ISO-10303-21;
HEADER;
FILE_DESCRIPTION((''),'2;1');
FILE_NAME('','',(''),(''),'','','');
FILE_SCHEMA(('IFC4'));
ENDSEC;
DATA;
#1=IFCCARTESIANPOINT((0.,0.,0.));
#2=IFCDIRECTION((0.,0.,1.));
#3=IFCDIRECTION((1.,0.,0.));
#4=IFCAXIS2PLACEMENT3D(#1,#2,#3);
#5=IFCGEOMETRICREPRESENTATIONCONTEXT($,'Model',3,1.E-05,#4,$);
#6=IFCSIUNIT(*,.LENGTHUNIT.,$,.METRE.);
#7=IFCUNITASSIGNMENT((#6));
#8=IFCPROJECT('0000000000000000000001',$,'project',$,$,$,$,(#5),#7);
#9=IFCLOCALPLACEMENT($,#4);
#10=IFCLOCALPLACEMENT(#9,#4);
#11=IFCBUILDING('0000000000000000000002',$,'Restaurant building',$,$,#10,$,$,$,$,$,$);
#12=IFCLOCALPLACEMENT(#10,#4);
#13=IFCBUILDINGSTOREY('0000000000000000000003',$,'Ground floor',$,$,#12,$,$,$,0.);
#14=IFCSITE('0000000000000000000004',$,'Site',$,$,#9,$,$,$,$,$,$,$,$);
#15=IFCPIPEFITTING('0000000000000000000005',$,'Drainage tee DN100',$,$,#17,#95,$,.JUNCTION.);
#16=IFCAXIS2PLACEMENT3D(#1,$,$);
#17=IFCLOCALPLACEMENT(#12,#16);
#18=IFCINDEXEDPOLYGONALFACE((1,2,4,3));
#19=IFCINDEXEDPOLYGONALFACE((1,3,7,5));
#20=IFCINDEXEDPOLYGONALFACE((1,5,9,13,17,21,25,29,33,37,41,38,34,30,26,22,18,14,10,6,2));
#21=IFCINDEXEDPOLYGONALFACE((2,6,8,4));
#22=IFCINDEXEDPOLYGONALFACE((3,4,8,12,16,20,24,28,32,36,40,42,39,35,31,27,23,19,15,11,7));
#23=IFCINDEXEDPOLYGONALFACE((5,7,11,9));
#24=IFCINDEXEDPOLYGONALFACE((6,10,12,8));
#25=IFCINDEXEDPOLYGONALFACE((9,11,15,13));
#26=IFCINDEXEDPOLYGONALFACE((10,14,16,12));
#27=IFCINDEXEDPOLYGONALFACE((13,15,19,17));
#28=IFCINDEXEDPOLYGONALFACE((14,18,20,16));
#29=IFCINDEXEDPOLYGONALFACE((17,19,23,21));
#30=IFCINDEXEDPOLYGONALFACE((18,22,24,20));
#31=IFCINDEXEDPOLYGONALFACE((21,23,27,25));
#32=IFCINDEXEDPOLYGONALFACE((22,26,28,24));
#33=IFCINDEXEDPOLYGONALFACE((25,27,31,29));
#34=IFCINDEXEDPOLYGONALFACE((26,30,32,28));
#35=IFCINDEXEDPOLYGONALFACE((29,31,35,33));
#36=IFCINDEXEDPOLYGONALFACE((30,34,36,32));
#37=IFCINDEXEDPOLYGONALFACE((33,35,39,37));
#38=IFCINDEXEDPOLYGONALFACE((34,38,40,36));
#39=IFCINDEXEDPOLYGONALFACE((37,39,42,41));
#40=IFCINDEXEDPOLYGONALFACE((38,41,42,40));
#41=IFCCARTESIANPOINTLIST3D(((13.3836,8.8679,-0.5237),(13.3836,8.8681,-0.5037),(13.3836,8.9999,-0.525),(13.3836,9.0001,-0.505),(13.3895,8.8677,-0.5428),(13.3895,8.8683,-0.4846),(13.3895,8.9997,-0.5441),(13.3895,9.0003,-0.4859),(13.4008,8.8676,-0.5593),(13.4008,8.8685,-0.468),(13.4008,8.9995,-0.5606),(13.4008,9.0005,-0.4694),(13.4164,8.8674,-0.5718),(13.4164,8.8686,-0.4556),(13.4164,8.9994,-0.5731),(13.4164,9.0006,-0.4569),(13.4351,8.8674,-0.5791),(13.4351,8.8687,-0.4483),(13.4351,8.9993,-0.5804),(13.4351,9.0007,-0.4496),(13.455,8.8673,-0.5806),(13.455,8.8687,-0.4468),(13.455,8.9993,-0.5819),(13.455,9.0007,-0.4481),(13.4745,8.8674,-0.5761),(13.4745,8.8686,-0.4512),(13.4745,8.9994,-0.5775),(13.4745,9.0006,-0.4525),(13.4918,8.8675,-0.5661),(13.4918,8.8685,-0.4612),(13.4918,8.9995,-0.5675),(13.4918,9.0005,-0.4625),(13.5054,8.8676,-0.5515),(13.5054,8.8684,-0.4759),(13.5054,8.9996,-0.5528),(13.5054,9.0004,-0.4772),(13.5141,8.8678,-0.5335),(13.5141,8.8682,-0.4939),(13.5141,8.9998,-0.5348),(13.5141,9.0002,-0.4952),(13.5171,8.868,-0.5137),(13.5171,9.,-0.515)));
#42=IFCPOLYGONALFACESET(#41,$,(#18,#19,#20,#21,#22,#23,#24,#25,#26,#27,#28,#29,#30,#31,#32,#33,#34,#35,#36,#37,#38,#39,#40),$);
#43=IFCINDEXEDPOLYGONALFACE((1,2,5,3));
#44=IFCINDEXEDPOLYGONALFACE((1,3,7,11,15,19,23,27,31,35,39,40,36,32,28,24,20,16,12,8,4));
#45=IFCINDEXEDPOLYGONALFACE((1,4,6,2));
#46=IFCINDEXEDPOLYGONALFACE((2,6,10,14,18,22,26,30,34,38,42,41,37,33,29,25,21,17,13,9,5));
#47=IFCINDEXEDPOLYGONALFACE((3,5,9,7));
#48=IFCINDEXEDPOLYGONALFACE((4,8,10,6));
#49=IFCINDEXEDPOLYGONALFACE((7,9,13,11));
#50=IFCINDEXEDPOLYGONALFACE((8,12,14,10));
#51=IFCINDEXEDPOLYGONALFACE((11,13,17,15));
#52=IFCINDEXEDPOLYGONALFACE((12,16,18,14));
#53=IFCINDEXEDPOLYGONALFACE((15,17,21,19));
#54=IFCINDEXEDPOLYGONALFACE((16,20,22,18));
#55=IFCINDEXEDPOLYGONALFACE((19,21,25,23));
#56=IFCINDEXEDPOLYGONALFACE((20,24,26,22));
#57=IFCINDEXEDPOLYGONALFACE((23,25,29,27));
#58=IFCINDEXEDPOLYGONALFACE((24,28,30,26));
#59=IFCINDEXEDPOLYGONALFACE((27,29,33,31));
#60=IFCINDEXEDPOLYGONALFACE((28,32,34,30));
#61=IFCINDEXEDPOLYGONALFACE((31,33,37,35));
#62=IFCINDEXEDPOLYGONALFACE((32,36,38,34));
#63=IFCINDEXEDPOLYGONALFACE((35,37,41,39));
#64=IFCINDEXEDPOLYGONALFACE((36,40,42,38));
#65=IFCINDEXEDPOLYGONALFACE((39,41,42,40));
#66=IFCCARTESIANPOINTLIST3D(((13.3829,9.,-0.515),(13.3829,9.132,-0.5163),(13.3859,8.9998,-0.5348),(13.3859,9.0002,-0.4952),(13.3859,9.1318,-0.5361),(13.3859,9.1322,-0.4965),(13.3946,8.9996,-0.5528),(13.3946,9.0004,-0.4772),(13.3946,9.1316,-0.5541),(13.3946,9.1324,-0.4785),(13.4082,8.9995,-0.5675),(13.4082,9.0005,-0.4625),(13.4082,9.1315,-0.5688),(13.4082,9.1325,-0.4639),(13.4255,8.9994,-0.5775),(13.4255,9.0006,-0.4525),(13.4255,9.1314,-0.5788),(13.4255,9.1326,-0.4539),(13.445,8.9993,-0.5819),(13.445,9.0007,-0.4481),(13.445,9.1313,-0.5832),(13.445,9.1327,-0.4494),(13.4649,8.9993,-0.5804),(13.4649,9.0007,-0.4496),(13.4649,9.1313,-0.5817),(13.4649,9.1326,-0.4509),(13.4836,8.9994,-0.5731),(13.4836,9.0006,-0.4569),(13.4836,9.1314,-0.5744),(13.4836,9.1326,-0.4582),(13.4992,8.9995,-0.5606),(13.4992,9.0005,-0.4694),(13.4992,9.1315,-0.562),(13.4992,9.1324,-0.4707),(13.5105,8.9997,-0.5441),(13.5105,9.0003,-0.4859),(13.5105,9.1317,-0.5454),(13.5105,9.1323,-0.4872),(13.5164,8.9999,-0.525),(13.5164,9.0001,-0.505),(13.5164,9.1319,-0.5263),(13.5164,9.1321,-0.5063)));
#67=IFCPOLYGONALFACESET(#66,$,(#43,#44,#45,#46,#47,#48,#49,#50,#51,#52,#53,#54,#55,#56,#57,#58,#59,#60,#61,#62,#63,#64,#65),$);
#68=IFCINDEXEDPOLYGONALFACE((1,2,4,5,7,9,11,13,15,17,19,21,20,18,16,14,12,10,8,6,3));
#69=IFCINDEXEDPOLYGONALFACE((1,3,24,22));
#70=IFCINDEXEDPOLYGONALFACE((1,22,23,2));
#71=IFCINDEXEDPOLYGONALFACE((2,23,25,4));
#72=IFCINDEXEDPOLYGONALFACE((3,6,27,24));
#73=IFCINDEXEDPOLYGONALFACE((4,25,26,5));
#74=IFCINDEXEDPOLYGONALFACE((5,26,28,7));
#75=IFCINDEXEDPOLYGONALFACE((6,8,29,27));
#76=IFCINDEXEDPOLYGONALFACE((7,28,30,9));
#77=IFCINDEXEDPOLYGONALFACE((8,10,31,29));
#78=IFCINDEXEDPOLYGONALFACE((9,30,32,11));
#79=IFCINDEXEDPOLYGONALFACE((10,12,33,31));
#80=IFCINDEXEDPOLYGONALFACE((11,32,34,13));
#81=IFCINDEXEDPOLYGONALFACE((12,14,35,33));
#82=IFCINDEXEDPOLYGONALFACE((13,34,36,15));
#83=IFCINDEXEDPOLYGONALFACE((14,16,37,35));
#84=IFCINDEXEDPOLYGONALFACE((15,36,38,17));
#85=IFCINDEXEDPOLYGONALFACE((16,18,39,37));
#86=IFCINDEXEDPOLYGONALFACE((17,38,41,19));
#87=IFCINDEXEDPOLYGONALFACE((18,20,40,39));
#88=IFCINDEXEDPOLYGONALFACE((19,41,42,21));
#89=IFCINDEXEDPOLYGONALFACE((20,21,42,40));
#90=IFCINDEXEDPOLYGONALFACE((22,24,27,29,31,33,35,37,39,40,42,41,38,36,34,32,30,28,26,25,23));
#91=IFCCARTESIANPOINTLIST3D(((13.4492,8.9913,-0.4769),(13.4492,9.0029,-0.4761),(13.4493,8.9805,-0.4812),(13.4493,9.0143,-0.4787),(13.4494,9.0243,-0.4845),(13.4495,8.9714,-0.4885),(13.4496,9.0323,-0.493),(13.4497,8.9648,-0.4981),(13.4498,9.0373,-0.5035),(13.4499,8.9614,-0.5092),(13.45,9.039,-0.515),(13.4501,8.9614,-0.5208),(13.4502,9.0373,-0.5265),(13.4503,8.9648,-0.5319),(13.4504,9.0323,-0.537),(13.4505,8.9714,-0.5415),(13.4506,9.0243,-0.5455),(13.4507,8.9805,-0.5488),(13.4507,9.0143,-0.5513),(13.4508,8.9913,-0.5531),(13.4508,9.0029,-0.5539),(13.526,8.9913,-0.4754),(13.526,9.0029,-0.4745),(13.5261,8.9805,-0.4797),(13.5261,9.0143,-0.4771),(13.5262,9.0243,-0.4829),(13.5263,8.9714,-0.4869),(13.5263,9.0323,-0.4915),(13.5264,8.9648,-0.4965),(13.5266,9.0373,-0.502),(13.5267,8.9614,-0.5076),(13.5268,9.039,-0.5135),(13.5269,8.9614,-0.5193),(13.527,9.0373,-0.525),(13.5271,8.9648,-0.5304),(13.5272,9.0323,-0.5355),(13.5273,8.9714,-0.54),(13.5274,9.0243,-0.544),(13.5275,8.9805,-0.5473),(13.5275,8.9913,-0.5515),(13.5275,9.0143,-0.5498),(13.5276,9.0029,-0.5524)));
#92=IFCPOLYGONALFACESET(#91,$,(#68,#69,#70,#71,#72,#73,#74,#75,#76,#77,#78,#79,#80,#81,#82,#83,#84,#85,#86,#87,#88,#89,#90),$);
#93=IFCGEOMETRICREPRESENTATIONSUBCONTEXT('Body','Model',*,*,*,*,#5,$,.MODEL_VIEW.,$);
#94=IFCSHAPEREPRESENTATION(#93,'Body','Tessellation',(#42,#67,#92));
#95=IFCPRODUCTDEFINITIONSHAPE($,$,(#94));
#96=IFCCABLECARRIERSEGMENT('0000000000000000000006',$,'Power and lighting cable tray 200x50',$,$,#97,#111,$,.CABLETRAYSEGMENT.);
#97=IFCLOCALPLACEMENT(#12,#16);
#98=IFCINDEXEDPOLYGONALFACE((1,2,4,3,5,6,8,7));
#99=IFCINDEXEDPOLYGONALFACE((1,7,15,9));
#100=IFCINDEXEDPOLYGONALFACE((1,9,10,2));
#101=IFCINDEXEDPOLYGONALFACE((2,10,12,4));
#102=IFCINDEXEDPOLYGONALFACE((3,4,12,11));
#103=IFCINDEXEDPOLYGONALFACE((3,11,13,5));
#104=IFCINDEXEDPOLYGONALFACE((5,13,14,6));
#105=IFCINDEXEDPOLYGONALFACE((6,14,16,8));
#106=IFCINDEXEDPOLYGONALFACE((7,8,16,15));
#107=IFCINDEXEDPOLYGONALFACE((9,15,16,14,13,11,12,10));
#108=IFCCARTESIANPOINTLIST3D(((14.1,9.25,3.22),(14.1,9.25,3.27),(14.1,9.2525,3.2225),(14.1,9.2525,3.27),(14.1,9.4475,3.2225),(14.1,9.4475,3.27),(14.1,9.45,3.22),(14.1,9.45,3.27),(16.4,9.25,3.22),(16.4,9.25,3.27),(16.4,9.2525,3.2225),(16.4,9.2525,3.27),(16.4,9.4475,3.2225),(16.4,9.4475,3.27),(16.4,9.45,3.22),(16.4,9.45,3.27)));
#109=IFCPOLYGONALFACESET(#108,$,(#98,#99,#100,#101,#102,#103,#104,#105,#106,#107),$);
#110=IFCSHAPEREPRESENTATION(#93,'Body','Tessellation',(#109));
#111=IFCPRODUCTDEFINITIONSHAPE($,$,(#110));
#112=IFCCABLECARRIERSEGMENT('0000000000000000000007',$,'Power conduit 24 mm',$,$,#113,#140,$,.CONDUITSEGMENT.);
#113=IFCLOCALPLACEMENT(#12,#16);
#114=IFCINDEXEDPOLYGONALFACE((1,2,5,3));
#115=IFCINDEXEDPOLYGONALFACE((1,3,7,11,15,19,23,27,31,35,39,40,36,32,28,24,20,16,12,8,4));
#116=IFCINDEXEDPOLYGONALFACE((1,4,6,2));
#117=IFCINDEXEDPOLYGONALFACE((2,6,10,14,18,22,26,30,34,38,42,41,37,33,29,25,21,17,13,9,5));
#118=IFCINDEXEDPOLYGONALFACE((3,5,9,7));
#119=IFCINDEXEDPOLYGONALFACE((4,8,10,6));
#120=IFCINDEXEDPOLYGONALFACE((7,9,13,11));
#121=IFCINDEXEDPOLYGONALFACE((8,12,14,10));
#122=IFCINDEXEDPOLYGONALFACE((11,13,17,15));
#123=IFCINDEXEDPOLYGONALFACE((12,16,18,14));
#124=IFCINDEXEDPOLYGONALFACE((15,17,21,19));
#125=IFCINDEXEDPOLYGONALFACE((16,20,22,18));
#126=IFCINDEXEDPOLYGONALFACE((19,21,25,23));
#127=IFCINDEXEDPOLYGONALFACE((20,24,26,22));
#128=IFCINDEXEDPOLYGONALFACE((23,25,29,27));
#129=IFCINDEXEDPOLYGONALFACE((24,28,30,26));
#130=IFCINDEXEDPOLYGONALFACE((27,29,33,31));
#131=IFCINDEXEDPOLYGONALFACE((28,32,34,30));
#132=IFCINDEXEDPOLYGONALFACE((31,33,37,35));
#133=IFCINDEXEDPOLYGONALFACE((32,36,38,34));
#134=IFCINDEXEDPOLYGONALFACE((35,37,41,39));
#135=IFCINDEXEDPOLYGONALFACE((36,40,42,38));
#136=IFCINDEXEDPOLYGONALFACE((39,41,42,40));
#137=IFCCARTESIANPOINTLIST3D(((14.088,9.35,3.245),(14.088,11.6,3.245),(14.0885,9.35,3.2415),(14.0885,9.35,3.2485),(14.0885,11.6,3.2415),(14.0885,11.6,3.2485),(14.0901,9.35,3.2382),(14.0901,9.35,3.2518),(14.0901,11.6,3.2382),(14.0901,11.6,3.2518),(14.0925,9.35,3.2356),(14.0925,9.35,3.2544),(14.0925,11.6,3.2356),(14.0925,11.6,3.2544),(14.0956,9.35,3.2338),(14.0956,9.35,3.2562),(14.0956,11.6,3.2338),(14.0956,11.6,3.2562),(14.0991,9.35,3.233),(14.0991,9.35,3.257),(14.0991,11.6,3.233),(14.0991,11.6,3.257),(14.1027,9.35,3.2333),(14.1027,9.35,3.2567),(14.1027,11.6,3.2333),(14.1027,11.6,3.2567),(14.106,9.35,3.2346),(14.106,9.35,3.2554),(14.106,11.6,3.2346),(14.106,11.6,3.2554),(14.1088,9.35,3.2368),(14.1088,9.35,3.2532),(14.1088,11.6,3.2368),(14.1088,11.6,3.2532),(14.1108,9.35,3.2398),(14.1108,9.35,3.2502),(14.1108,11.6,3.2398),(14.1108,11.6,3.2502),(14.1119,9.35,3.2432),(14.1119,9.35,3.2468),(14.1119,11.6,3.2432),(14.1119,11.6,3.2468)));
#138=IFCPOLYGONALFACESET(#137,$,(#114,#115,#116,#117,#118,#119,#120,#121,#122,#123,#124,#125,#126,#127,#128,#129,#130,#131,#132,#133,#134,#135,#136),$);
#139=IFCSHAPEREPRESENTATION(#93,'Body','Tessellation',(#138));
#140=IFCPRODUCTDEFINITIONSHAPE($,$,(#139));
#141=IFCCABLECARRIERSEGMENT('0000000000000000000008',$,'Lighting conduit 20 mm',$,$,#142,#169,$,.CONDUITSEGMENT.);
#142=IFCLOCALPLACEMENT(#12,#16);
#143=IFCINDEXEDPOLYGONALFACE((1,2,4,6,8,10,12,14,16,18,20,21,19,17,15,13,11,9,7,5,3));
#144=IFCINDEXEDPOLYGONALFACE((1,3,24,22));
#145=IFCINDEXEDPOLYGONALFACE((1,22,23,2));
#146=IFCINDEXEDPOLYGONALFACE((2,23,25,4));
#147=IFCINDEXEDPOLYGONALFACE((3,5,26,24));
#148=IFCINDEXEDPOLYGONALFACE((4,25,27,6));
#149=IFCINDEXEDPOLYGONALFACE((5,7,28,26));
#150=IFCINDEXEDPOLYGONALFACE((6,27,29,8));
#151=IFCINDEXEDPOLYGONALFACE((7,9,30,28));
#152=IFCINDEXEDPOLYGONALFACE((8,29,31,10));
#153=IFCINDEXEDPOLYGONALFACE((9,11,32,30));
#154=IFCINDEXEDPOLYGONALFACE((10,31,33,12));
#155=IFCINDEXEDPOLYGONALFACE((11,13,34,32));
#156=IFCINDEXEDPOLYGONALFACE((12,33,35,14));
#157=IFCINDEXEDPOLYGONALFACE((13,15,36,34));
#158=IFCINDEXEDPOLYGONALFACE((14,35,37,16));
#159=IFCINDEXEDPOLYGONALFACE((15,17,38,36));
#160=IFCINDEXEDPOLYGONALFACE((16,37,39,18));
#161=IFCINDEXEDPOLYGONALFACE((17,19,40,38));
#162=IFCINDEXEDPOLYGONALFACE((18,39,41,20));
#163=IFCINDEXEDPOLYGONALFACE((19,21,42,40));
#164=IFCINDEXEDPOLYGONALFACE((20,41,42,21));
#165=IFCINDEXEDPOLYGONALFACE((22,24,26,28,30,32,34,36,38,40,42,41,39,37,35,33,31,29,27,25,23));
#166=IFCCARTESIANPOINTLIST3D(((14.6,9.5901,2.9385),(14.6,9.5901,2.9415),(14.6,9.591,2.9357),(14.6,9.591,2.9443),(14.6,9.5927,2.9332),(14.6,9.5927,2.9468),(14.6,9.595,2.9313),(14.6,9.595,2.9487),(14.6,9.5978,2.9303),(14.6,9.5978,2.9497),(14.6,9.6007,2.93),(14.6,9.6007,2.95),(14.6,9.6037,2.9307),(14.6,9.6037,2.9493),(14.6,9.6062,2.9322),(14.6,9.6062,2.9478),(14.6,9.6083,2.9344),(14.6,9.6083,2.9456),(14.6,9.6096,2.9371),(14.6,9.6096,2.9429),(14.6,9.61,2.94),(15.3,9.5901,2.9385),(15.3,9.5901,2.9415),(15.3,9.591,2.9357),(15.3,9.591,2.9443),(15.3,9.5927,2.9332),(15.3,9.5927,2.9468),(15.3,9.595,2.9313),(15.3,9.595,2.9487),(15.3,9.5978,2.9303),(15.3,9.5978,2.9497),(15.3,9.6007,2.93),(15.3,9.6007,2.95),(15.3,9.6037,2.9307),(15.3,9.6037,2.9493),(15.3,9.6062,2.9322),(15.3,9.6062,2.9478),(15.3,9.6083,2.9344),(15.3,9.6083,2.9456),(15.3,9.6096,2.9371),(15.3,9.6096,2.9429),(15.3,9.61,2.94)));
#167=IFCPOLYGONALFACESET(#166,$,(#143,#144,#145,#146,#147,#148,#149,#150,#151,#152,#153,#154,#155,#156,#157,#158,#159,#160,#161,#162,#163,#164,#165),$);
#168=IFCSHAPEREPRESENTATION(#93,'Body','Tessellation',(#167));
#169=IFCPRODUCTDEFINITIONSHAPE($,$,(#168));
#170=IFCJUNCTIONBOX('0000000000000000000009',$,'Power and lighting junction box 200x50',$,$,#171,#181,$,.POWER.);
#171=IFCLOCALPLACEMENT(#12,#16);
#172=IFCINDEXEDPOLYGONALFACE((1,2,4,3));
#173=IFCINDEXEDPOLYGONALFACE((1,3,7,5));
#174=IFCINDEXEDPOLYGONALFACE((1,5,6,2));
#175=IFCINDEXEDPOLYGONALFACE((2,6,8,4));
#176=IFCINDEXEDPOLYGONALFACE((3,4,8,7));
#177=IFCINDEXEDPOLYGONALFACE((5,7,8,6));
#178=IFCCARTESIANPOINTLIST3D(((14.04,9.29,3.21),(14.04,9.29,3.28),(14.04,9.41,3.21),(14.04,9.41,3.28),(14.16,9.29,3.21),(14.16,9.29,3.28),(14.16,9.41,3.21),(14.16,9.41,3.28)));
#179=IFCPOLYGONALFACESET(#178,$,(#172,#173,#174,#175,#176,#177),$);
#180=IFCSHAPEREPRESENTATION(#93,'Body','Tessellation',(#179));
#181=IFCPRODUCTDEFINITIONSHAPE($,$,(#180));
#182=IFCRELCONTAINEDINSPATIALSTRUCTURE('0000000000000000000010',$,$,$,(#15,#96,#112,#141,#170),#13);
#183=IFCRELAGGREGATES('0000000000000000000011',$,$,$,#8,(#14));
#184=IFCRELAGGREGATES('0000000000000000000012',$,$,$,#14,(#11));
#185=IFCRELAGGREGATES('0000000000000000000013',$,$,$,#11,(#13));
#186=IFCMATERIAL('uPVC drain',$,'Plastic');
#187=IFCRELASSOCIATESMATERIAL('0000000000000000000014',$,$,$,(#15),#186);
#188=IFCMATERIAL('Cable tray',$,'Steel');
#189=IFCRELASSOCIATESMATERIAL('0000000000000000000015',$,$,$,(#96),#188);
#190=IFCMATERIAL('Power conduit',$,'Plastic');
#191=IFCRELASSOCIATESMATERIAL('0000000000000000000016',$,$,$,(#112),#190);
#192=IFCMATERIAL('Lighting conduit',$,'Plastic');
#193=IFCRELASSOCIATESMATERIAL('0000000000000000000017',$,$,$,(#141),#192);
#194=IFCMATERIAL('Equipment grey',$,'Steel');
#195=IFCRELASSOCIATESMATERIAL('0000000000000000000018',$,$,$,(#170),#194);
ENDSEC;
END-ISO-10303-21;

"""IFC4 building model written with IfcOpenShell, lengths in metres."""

from ifc_helpers import new_model, si_unit, frame, origin_with_axes, origin_2d, place, context, subcontext, project, spatial, polyline, rectangle, circle, outline, extrude, material, element, save


model = new_model("IFC4")

# Units and contexts
model_context = context("Model", 3, precision=1e-05, world=origin_with_axes())
body_context = subcontext(model_context, "Body", "Model", "MODEL_VIEW")
ifc_project = project(units=[si_unit("LENGTHUNIT", "METRE")], contexts=[model_context])

# Site, building, storey
site_placement = place(None, origin_with_axes())
site = spatial("IfcSite", under=ifc_project, at=site_placement, Name="Site")
building_placement = place(site_placement, origin_with_axes())
building = spatial("IfcBuilding", under=site, at=building_placement, Name="Restaurant building")
storey_placement = place(building_placement, origin_with_axes())
storey = spatial("IfcBuildingStorey", under=building, at=storey_placement, Name="Ground floor", Elevation=0.0)

# Shared definitions
ifc_material_1 = material(Name="uPVC drain", Category="Plastic")

# Pipe fitting
pipe_fitting_1_placement = place(storey_placement, frame((13.45, 9.0, -0.515)))
element("IfcPipeFitting", 1, at=pipe_fitting_1_placement, inside=storey, material=ifc_material_1, Name="Drainage tee DN100", PredefinedType="JUNCTION", context=body_context, shape_type="SweptSolid", body=[
    extrude(circle(Radius=0.0671, at=origin_2d()), frame((0.0, 0.0, 0.0), z_axis=(0.0, -0.99995, 0.009999), x_axis=(1.0, 0.0, 0.0)), (0.0, 0.0, 1.0), 0.132),
    extrude(circle(Radius=0.0671, at=origin_2d()), frame((0.0, 0.0, 0.0), z_axis=(0.0, 0.99995, -0.009999), x_axis=(-1.0, 0.0, 0.0)), (0.0, 0.0, 1.0), 0.132),
    extrude(circle(Radius=0.039, at=origin_2d()), frame((0.0, 0.0, 0.0), z_axis=(0.9998, 0.0, 0.019996), x_axis=(0.0, 1.0, 0.0)), (0.0, 0.0, 1.0), 0.0768),
])

# Cable carrier segments
ifc_material_2 = material(Name="Cable tray", Category="Steel")
cable_carrier_segment_1_placement = place(storey_placement, frame((14.1, 9.35, 3.245)))
element("IfcCableCarrierSegment", 2, at=cable_carrier_segment_1_placement, inside=storey, material=ifc_material_2, Name="Power and lighting cable tray 200x50", PredefinedType="CABLETRAYSEGMENT", context=body_context, shape_type="SweptSolid", body=[
    extrude(outline(polyline([(-0.1, -0.025), (0.1, -0.025), (0.1, 0.025), (0.0975, 0.025), (0.0975, -0.0225), (-0.0975, -0.0225), (-0.0975, 0.025), (-0.1, 0.025), (-0.1, -0.025)])), frame((0.0, 0.0, 0.0), z_axis=(1.0, 0.0, 0.0), x_axis=(0.0, 1.0, 0.0)), (0.0, 0.0, 1.0), 2.3),
])
ifc_material_3 = material(Name="Power conduit", Category="Plastic")
cable_carrier_segment_2_placement = place(storey_placement, frame((14.1, 9.35, 3.245)))
element("IfcCableCarrierSegment", 3, at=cable_carrier_segment_2_placement, inside=storey, material=ifc_material_3, Name="Power conduit 24 mm", PredefinedType="CONDUITSEGMENT", context=body_context, shape_type="SweptSolid", body=[
    extrude(circle(Radius=0.012, at=origin_2d()), frame((0.0, 0.0, 0.0), z_axis=(0.0, 1.0, 0.0), x_axis=(-1.0, 0.0, 0.0)), (0.0, 0.0, 1.0), 2.25),
])
ifc_material_4 = material(Name="Lighting conduit", Category="Plastic")
cable_carrier_segment_3_placement = place(storey_placement, frame((14.6, 9.6, 2.94)))
element("IfcCableCarrierSegment", 4, at=cable_carrier_segment_3_placement, inside=storey, material=ifc_material_4, Name="Lighting conduit 20 mm", PredefinedType="CONDUITSEGMENT", context=body_context, shape_type="SweptSolid", body=[
    extrude(circle(Radius=0.01, at=origin_2d()), frame((0.0, 0.0, 0.0), z_axis=(1.0, 0.0, 0.0), x_axis=(0.0, 1.0, 0.0)), (0.0, 0.0, 1.0), 0.7),
])

# Junction box
ifc_material_5 = material(Name="Equipment grey", Category="Steel")
junction_box_placement = place(storey_placement, frame((14.1, 9.35, 3.245)))
element("IfcJunctionBox", 5, at=junction_box_placement, inside=storey, material=ifc_material_5, Name="Power and lighting junction box 200x50", PredefinedType="POWER", context=body_context, shape_type="SweptSolid", body=[
    extrude(rectangle(XDim=0.12, YDim=0.12, at=origin_2d()), frame((0.0, 0.0, -0.035)), (0.0, 0.0, 1.0), 0.07),
])

save(model, "model.ifc")
